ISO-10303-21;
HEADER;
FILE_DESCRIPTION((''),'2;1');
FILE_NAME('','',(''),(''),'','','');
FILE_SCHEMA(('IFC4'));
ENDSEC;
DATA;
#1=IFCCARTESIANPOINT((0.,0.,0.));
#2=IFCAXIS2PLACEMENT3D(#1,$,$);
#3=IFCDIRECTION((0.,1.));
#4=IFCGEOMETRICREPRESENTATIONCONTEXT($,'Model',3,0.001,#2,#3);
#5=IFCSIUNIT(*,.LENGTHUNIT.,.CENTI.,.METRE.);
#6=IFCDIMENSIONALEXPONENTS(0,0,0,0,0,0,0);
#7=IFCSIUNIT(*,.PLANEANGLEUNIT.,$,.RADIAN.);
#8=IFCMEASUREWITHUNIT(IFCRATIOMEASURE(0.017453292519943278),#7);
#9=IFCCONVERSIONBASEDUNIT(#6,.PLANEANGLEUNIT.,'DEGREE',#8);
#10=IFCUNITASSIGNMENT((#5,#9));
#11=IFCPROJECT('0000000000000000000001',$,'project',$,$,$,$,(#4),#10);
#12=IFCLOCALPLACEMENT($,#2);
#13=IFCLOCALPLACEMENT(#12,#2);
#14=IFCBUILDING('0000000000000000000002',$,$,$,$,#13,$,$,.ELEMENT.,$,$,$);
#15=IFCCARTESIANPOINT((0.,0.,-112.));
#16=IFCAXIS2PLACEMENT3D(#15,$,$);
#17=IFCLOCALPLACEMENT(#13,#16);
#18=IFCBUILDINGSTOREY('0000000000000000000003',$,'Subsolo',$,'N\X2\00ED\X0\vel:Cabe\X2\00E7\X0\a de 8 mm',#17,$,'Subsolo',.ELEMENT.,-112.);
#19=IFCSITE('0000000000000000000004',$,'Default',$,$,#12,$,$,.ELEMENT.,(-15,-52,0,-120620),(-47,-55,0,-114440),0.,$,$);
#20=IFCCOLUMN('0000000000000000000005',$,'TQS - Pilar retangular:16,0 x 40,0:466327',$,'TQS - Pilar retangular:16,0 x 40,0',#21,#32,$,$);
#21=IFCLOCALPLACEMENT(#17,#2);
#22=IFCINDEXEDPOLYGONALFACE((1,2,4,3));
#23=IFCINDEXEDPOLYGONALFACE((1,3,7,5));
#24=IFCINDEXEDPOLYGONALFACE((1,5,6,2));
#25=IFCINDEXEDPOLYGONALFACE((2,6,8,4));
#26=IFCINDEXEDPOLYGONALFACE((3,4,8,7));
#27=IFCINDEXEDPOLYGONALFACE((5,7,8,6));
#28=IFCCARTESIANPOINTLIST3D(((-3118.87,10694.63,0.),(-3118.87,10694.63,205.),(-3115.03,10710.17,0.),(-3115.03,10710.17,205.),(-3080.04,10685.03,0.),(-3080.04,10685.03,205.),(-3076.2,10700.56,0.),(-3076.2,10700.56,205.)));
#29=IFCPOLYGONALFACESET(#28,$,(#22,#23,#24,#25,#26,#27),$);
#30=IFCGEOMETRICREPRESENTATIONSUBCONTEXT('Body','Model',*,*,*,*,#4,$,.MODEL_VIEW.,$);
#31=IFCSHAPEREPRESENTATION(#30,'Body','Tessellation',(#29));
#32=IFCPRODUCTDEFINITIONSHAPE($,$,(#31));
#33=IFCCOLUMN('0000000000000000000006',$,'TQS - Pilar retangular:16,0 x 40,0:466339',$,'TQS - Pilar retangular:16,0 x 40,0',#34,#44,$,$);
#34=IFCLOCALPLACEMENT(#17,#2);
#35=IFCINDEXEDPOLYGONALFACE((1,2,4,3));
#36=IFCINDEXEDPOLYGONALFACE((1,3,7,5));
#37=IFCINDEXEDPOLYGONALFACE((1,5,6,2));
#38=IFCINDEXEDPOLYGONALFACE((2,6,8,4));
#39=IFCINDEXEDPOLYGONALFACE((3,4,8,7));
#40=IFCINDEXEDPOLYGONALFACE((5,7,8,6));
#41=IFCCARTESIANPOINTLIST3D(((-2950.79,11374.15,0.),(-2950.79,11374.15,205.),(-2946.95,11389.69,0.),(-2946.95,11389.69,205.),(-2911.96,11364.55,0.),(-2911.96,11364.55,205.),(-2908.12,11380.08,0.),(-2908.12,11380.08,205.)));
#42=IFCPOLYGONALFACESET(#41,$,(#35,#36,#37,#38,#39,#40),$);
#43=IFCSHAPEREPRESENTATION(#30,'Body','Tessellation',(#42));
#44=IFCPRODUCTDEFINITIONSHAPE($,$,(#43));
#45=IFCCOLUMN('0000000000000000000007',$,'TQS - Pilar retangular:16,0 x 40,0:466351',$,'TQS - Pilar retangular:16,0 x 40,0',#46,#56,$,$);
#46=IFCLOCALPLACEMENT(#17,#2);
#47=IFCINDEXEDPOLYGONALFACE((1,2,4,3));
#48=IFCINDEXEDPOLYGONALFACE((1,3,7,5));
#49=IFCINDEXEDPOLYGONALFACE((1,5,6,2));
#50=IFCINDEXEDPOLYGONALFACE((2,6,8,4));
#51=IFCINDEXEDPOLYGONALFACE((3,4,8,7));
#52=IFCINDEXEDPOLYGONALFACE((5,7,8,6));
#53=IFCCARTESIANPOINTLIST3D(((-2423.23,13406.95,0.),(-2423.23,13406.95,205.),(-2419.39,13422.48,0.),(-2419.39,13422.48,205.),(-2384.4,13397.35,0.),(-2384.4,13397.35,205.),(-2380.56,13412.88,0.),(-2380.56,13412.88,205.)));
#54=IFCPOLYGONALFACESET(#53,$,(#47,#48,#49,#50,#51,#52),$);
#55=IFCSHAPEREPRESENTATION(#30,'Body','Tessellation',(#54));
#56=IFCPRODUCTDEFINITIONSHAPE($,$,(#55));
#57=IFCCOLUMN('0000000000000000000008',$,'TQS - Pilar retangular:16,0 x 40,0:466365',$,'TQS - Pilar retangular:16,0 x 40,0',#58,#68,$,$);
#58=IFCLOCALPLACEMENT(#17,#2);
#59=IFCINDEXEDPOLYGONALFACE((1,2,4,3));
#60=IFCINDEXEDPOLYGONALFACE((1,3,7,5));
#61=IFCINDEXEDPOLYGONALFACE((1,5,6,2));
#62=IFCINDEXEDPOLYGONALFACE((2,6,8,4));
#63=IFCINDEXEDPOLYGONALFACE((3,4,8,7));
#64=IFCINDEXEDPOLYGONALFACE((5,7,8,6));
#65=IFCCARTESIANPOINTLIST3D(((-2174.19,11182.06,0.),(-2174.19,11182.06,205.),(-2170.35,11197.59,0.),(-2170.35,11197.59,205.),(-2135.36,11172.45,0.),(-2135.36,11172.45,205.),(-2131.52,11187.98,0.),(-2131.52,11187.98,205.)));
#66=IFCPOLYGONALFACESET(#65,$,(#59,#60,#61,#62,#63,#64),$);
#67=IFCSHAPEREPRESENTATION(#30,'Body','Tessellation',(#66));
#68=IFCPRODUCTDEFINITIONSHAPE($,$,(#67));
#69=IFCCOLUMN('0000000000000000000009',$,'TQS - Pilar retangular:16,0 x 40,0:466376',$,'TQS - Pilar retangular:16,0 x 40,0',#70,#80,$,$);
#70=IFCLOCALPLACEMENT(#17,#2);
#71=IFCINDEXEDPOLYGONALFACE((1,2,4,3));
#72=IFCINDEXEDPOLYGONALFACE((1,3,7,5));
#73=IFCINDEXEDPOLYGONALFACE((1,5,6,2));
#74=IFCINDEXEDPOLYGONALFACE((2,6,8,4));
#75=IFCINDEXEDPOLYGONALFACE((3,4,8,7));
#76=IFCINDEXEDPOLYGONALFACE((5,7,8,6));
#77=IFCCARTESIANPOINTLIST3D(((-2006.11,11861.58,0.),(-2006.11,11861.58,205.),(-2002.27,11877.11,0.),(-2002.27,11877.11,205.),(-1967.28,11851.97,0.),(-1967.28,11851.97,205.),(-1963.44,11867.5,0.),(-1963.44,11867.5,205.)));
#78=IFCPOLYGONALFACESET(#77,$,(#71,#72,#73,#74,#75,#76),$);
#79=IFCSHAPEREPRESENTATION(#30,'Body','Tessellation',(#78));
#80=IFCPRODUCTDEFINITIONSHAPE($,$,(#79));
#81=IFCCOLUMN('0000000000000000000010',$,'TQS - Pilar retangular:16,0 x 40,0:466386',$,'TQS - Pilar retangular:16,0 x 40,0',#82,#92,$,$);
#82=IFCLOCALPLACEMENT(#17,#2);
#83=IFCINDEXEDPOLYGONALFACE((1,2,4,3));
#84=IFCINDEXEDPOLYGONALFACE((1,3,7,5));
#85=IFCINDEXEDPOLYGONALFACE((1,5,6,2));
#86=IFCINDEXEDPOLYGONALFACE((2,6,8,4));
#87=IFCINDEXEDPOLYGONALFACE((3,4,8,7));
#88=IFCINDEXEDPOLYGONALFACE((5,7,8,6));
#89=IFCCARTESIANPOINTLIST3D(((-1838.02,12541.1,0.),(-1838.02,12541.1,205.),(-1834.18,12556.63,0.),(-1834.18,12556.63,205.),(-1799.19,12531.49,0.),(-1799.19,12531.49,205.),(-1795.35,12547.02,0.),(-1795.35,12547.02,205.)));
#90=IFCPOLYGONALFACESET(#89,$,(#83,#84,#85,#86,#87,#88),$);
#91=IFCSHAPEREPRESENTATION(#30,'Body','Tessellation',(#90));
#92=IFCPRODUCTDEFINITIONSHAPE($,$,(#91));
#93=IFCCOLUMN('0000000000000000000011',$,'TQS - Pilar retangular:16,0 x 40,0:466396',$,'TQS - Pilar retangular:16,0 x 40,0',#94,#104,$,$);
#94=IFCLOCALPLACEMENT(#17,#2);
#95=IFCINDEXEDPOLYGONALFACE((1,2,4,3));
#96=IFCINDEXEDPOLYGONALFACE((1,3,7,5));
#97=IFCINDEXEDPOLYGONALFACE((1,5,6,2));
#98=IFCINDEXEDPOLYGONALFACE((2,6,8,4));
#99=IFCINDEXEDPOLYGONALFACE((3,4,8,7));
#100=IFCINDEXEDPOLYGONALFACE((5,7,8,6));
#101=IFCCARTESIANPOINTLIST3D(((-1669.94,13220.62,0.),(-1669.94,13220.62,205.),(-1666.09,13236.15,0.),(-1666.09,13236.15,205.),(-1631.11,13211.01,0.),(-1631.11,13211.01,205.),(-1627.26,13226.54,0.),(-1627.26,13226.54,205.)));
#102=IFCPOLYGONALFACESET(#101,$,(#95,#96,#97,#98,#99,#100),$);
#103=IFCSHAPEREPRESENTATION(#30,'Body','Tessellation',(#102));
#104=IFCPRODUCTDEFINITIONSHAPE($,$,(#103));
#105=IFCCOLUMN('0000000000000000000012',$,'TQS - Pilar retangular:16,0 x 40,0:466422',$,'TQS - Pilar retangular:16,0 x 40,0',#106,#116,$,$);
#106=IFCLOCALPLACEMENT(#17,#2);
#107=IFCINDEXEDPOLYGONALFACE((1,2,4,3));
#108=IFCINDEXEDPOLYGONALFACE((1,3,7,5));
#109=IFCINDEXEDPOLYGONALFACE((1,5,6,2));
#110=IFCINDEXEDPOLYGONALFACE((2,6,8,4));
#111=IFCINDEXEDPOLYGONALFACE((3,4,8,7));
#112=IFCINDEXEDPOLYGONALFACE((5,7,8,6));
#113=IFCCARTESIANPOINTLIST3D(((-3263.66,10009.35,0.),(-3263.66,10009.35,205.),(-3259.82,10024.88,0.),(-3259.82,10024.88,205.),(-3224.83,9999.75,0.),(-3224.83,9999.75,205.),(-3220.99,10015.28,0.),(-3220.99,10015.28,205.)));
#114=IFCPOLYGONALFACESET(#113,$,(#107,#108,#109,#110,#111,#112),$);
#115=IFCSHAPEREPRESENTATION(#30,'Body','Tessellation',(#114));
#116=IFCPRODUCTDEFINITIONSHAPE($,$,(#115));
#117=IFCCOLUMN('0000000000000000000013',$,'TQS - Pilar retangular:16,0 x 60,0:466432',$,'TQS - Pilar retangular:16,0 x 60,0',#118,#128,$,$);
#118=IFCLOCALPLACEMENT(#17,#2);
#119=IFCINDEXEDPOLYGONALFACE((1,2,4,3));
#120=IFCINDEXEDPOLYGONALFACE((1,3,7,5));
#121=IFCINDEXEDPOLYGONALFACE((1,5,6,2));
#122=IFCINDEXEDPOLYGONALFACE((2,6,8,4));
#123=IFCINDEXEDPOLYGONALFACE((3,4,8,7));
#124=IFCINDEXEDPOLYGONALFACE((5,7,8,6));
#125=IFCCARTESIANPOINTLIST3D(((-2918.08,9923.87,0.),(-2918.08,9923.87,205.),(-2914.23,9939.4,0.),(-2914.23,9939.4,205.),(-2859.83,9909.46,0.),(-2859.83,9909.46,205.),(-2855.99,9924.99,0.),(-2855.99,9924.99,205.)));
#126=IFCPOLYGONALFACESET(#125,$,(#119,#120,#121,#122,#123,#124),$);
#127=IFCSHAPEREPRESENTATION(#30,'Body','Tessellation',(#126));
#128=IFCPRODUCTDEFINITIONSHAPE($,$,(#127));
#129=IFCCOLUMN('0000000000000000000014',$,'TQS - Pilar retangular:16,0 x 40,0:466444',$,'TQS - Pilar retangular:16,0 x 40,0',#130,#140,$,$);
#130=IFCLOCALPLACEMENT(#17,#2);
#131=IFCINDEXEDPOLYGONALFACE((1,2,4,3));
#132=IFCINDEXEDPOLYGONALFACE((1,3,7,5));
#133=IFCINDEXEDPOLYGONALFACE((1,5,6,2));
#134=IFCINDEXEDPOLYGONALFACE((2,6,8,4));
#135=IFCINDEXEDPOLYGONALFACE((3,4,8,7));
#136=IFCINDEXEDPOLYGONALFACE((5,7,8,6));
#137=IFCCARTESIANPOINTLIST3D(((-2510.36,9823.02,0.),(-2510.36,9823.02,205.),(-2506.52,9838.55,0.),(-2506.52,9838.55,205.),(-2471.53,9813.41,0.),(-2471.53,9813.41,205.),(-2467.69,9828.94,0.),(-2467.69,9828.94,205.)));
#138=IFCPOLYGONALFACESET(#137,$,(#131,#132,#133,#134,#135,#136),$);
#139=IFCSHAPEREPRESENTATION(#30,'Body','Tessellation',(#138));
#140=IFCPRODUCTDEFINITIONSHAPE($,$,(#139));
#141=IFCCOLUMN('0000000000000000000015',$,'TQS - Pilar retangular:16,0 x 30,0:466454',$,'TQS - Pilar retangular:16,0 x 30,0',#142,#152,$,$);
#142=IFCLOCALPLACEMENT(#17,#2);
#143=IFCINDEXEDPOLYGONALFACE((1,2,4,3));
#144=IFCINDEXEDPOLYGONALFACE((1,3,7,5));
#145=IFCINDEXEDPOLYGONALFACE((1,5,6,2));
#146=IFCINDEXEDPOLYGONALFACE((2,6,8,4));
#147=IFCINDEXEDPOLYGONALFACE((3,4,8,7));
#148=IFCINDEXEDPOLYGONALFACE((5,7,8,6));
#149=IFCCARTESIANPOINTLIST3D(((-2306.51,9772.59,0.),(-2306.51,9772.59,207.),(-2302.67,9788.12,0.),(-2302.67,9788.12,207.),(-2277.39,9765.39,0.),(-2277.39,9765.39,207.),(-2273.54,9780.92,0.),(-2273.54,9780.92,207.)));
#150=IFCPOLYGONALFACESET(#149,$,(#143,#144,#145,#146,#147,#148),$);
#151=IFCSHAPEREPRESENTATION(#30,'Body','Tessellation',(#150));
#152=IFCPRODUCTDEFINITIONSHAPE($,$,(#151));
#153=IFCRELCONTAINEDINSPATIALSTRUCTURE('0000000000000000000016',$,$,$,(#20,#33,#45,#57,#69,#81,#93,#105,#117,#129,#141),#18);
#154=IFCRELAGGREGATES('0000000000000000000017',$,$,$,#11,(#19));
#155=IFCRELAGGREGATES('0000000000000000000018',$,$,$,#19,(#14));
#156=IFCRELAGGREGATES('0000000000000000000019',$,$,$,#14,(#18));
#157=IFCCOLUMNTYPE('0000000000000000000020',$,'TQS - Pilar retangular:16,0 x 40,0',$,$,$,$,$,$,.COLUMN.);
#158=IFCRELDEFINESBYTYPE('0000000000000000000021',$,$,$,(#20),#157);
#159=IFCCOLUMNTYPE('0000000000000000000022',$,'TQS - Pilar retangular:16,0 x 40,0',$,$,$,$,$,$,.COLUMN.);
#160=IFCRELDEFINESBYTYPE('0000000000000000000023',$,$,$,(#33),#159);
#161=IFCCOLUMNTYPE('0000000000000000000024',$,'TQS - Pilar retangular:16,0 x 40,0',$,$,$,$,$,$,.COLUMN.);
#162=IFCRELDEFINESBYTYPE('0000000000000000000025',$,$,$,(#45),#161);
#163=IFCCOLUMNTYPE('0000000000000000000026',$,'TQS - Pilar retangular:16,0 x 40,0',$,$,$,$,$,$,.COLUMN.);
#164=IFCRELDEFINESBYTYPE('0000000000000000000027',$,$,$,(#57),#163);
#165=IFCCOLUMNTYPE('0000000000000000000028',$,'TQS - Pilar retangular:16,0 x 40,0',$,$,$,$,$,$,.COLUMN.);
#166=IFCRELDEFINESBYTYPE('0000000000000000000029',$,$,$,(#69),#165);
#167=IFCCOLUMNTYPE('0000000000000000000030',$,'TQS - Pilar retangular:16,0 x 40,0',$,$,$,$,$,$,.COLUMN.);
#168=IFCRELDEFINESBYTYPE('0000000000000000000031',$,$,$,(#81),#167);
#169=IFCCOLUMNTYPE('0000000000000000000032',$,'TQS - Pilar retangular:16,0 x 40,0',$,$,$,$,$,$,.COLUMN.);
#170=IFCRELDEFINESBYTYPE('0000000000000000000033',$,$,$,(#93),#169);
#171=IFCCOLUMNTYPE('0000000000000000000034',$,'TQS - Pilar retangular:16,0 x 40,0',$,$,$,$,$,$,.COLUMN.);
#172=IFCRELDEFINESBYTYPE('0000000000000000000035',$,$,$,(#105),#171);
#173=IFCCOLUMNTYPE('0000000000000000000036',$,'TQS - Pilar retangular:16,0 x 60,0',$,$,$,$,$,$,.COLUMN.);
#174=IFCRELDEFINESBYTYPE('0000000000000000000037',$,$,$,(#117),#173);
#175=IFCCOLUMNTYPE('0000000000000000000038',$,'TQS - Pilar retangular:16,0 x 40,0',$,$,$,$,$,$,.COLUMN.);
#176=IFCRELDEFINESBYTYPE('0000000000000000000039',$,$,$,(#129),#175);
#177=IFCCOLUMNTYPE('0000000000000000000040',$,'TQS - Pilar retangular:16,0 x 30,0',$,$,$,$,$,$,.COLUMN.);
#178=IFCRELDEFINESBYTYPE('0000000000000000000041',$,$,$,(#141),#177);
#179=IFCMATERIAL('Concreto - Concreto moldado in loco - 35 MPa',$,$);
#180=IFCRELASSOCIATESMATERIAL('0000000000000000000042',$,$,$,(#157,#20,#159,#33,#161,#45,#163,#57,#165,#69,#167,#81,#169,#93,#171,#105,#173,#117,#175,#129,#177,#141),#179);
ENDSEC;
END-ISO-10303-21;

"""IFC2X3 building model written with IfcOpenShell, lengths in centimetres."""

from ifc_helpers import new_model, entity, si_unit, converted_unit, direction, frame, origin, origin_2d_with_axis, place, context, subcontext, project, spatial, rectangle, extrude, source, transform, mapped, material, type_object, type_shapes, element, save


model = new_model("IFC2X3")

# Units and contexts
model_context = context("Model", 3, precision=0.001, world=origin(), true_north=direction((0.0, 1.0)))
body_context = subcontext(model_context, "Body", "Model", "MODEL_VIEW")
ifc_project = project(units=[si_unit("LENGTHUNIT", "METRE", prefix="CENTI"), converted_unit("PLANEANGLEUNIT", "DEGREE", entity("IfcRatioMeasure", 0.017453292519943278), si_unit("PLANEANGLEUNIT", "RADIAN"), dimensions=[0, 0, 0, 0, 0, 0, 0])], contexts=[model_context])

# Site, building, storey
site_placement = place(None, origin())
site = spatial("IfcSite", under=ifc_project, at=site_placement, Name="Default", CompositionType="ELEMENT", RefLatitude=(-15, -52, 0, -120620), RefLongitude=(-47, -55, 0, -114440), RefElevation=0.0)
building_placement = place(site_placement, origin())
building = spatial("IfcBuilding", under=site, at=building_placement, CompositionType="ELEMENT")
storey_placement = place(building_placement, frame((0.0, 0.0, -112.0)))
storey = spatial("IfcBuildingStorey", under=building, at=storey_placement, Name="Subsolo", ObjectType="Nível:Cabeça de 8 mm", LongName="Subsolo", CompositionType="ELEMENT", Elevation=-112.0)

# Columns
ifc_material_1 = material(Name="Concreto - Concreto moldado in loco - 35 MPa")
column_type_1 = type_object("IfcColumnType", Name="TQS - Pilar retangular:16,0 x 40,0", PredefinedType="COLUMN", material=ifc_material_1)
shared_shape_1 = source(origin(), body_context, "Body", "SweptSolid", [
    extrude(rectangle(XDim=40.0, YDim=16.0, at=origin_2d_with_axis()), frame((-3097.54, 10697.6, -112.0), z_axis=(0.0, 0.0, 1.0), x_axis=(-0.970743, 0.240122, 0.0)), (0.0, 0.0, 1.0), 205.0),
])
type_shapes(column_type_1, [shared_shape_1])
column_1_placement = place(storey_placement, frame((0.0, 0.0, 112.0)))
element("IfcColumn", 1, at=column_1_placement, inside=storey, type_object=column_type_1, material=ifc_material_1, Name="TQS - Pilar retangular:16,0 x 40,0:466327", ObjectType="TQS - Pilar retangular:16,0 x 40,0", context=body_context, shape_type="MappedRepresentation", body=[
    mapped(shared_shape_1, transform((0.0, 0.0, 0.0), scale=1.0)),
])
column_type_2 = type_object("IfcColumnType", Name="TQS - Pilar retangular:16,0 x 40,0", PredefinedType="COLUMN", material=ifc_material_1)
shared_shape_2 = source(origin(), body_context, "Body", "SweptSolid", [
    extrude(rectangle(XDim=40.0, YDim=16.0, at=origin_2d_with_axis()), frame((-2929.45, 11377.12, -112.0), z_axis=(0.0, 0.0, 1.0), x_axis=(-0.970743, 0.240122, 0.0)), (0.0, 0.0, 1.0), 205.0),
])
type_shapes(column_type_2, [shared_shape_2])
column_2_placement = place(storey_placement, frame((0.0, 0.0, 112.0)))
element("IfcColumn", 2, at=column_2_placement, inside=storey, type_object=column_type_2, material=ifc_material_1, Name="TQS - Pilar retangular:16,0 x 40,0:466339", ObjectType="TQS - Pilar retangular:16,0 x 40,0", context=body_context, shape_type="MappedRepresentation", body=[
    mapped(shared_shape_2, transform((0.0, 0.0, 0.0), scale=1.0)),
])
column_type_3 = type_object("IfcColumnType", Name="TQS - Pilar retangular:16,0 x 40,0", PredefinedType="COLUMN", material=ifc_material_1)
shared_shape_3 = source(origin(), body_context, "Body", "SweptSolid", [
    extrude(rectangle(XDim=40.0, YDim=16.0, at=origin_2d_with_axis()), frame((-2401.9, 13409.91, -112.0), z_axis=(0.0, 0.0, 1.0), x_axis=(-0.970743, 0.240122, 0.0)), (0.0, 0.0, 1.0), 205.0),
])
type_shapes(column_type_3, [shared_shape_3])
column_3_placement = place(storey_placement, frame((0.0, 0.0, 112.0)))
element("IfcColumn", 3, at=column_3_placement, inside=storey, type_object=column_type_3, material=ifc_material_1, Name="TQS - Pilar retangular:16,0 x 40,0:466351", ObjectType="TQS - Pilar retangular:16,0 x 40,0", context=body_context, shape_type="MappedRepresentation", body=[
    mapped(shared_shape_3, transform((0.0, 0.0, 0.0), scale=1.0)),
])
column_type_4 = type_object("IfcColumnType", Name="TQS - Pilar retangular:16,0 x 40,0", PredefinedType="COLUMN", material=ifc_material_1)
shared_shape_4 = source(origin(), body_context, "Body", "SweptSolid", [
    extrude(rectangle(XDim=40.0, YDim=16.0, at=origin_2d_with_axis()), frame((-2152.86, 11185.02, -112.0), z_axis=(0.0, 0.0, 1.0), x_axis=(-0.970743, 0.240122, 0.0)), (0.0, 0.0, 1.0), 205.0),
])
type_shapes(column_type_4, [shared_shape_4])
column_4_placement = place(storey_placement, frame((0.0, 0.0, 112.0)))
element("IfcColumn", 4, at=column_4_placement, inside=storey, type_object=column_type_4, material=ifc_material_1, Name="TQS - Pilar retangular:16,0 x 40,0:466365", ObjectType="TQS - Pilar retangular:16,0 x 40,0", context=body_context, shape_type="MappedRepresentation", body=[
    mapped(shared_shape_4, transform((0.0, 0.0, 0.0), scale=1.0)),
])
column_type_5 = type_object("IfcColumnType", Name="TQS - Pilar retangular:16,0 x 40,0", PredefinedType="COLUMN", material=ifc_material_1)
shared_shape_5 = source(origin(), body_context, "Body", "SweptSolid", [
    extrude(rectangle(XDim=40.0, YDim=16.0, at=origin_2d_with_axis()), frame((-1984.77, 11864.54, -112.0), z_axis=(0.0, 0.0, 1.0), x_axis=(-0.970743, 0.240122, 0.0)), (0.0, 0.0, 1.0), 205.0),
])
type_shapes(column_type_5, [shared_shape_5])
column_5_placement = place(storey_placement, frame((0.0, 0.0, 112.0)))
element("IfcColumn", 5, at=column_5_placement, inside=storey, type_object=column_type_5, material=ifc_material_1, Name="TQS - Pilar retangular:16,0 x 40,0:466376", ObjectType="TQS - Pilar retangular:16,0 x 40,0", context=body_context, shape_type="MappedRepresentation", body=[
    mapped(shared_shape_5, transform((0.0, 0.0, 0.0), scale=1.0)),
])
column_type_6 = type_object("IfcColumnType", Name="TQS - Pilar retangular:16,0 x 40,0", PredefinedType="COLUMN", material=ifc_material_1)
shared_shape_6 = source(origin(), body_context, "Body", "SweptSolid", [
    extrude(rectangle(XDim=40.0, YDim=16.0, at=origin_2d_with_axis()), frame((-1816.69, 12544.06, -112.0), z_axis=(0.0, 0.0, 1.0), x_axis=(-0.970743, 0.240122, 0.0)), (0.0, 0.0, 1.0), 205.0),
])
type_shapes(column_type_6, [shared_shape_6])
column_6_placement = place(storey_placement, frame((0.0, 0.0, 112.0)))
element("IfcColumn", 6, at=column_6_placement, inside=storey, type_object=column_type_6, material=ifc_material_1, Name="TQS - Pilar retangular:16,0 x 40,0:466386", ObjectType="TQS - Pilar retangular:16,0 x 40,0", context=body_context, shape_type="MappedRepresentation", body=[
    mapped(shared_shape_6, transform((0.0, 0.0, 0.0), scale=1.0)),
])
column_type_7 = type_object("IfcColumnType", Name="TQS - Pilar retangular:16,0 x 40,0", PredefinedType="COLUMN", material=ifc_material_1)
shared_shape_7 = source(origin(), body_context, "Body", "SweptSolid", [
    extrude(rectangle(XDim=40.0, YDim=16.0, at=origin_2d_with_axis()), frame((-1648.6, 13223.58, -112.0), z_axis=(0.0, 0.0, 1.0), x_axis=(-0.970743, 0.240122, 0.0)), (0.0, 0.0, 1.0), 205.0),
])
type_shapes(column_type_7, [shared_shape_7])
column_7_placement = place(storey_placement, frame((0.0, 0.0, 112.0)))
element("IfcColumn", 7, at=column_7_placement, inside=storey, type_object=column_type_7, material=ifc_material_1, Name="TQS - Pilar retangular:16,0 x 40,0:466396", ObjectType="TQS - Pilar retangular:16,0 x 40,0", context=body_context, shape_type="MappedRepresentation", body=[
    mapped(shared_shape_7, transform((0.0, 0.0, 0.0), scale=1.0)),
])
column_type_8 = type_object("IfcColumnType", Name="TQS - Pilar retangular:16,0 x 40,0", PredefinedType="COLUMN", material=ifc_material_1)
shared_shape_8 = source(origin(), body_context, "Body", "SweptSolid", [
    extrude(rectangle(XDim=40.0, YDim=16.0, at=origin_2d_with_axis()), frame((-3242.33, 10012.31, -112.0), z_axis=(0.0, 0.0, 1.0), x_axis=(-0.970743, 0.240122, 0.0)), (0.0, 0.0, 1.0), 205.0),
])
type_shapes(column_type_8, [shared_shape_8])
column_8_placement = place(storey_placement, frame((0.0, 0.0, 112.0)))
element("IfcColumn", 8, at=column_8_placement, inside=storey, type_object=column_type_8, material=ifc_material_1, Name="TQS - Pilar retangular:16,0 x 40,0:466422", ObjectType="TQS - Pilar retangular:16,0 x 40,0", context=body_context, shape_type="MappedRepresentation", body=[
    mapped(shared_shape_8, transform((0.0, 0.0, 0.0), scale=1.0)),
])
column_type_9 = type_object("IfcColumnType", Name="TQS - Pilar retangular:16,0 x 60,0", PredefinedType="COLUMN", material=ifc_material_1)
shared_shape_9 = source(origin(), body_context, "Body", "SweptSolid", [
    extrude(rectangle(XDim=60.0, YDim=16.0, at=origin_2d_with_axis()), frame((-2887.03, 9924.43, -112.0), z_axis=(0.0, 0.0, 1.0), x_axis=(-0.970743, 0.240122, 0.0)), (0.0, 0.0, 1.0), 205.0),
])
type_shapes(column_type_9, [shared_shape_9])
column_9_placement = place(storey_placement, frame((0.0, 0.0, 112.0)))
element("IfcColumn", 9, at=column_9_placement, inside=storey, type_object=column_type_9, material=ifc_material_1, Name="TQS - Pilar retangular:16,0 x 60,0:466432", ObjectType="TQS - Pilar retangular:16,0 x 60,0", context=body_context, shape_type="MappedRepresentation", body=[
    mapped(shared_shape_9, transform((0.0, 0.0, 0.0), scale=1.0)),
])
column_type_10 = type_object("IfcColumnType", Name="TQS - Pilar retangular:16,0 x 40,0", PredefinedType="COLUMN", material=ifc_material_1)
shared_shape_10 = source(origin(), body_context, "Body", "SweptSolid", [
    extrude(rectangle(XDim=40.0, YDim=16.0, at=origin_2d_with_axis()), frame((-2489.03, 9825.98, -112.0), z_axis=(0.0, 0.0, 1.0), x_axis=(-0.970743, 0.240122, 0.0)), (0.0, 0.0, 1.0), 205.0),
])
type_shapes(column_type_10, [shared_shape_10])
column_10_placement = place(storey_placement, frame((0.0, 0.0, 112.0)))
element("IfcColumn", 10, at=column_10_placement, inside=storey, type_object=column_type_10, material=ifc_material_1, Name="TQS - Pilar retangular:16,0 x 40,0:466444", ObjectType="TQS - Pilar retangular:16,0 x 40,0", context=body_context, shape_type="MappedRepresentation", body=[
    mapped(shared_shape_10, transform((0.0, 0.0, 0.0), scale=1.0)),
])
column_type_11 = type_object("IfcColumnType", Name="TQS - Pilar retangular:16,0 x 30,0", PredefinedType="COLUMN", material=ifc_material_1)
shared_shape_11 = source(origin(), body_context, "Body", "SweptSolid", [
    extrude(rectangle(XDim=30.0, YDim=16.0, at=origin_2d_with_axis()), frame((-2290.03, 9776.75, -112.0), z_axis=(0.0, 0.0, 1.0), x_axis=(-0.970743, 0.240122, 0.0)), (0.0, 0.0, 1.0), 207.0),
])
type_shapes(column_type_11, [shared_shape_11])
column_11_placement = place(storey_placement, frame((0.0, 0.0, 112.0)))
element("IfcColumn", 11, at=column_11_placement, inside=storey, type_object=column_type_11, material=ifc_material_1, Name="TQS - Pilar retangular:16,0 x 30,0:466454", ObjectType="TQS - Pilar retangular:16,0 x 30,0", context=body_context, shape_type="MappedRepresentation", body=[
    mapped(shared_shape_11, transform((0.0, 0.0, 0.0), scale=1.0)),
])

save(model, "model.ifc")
